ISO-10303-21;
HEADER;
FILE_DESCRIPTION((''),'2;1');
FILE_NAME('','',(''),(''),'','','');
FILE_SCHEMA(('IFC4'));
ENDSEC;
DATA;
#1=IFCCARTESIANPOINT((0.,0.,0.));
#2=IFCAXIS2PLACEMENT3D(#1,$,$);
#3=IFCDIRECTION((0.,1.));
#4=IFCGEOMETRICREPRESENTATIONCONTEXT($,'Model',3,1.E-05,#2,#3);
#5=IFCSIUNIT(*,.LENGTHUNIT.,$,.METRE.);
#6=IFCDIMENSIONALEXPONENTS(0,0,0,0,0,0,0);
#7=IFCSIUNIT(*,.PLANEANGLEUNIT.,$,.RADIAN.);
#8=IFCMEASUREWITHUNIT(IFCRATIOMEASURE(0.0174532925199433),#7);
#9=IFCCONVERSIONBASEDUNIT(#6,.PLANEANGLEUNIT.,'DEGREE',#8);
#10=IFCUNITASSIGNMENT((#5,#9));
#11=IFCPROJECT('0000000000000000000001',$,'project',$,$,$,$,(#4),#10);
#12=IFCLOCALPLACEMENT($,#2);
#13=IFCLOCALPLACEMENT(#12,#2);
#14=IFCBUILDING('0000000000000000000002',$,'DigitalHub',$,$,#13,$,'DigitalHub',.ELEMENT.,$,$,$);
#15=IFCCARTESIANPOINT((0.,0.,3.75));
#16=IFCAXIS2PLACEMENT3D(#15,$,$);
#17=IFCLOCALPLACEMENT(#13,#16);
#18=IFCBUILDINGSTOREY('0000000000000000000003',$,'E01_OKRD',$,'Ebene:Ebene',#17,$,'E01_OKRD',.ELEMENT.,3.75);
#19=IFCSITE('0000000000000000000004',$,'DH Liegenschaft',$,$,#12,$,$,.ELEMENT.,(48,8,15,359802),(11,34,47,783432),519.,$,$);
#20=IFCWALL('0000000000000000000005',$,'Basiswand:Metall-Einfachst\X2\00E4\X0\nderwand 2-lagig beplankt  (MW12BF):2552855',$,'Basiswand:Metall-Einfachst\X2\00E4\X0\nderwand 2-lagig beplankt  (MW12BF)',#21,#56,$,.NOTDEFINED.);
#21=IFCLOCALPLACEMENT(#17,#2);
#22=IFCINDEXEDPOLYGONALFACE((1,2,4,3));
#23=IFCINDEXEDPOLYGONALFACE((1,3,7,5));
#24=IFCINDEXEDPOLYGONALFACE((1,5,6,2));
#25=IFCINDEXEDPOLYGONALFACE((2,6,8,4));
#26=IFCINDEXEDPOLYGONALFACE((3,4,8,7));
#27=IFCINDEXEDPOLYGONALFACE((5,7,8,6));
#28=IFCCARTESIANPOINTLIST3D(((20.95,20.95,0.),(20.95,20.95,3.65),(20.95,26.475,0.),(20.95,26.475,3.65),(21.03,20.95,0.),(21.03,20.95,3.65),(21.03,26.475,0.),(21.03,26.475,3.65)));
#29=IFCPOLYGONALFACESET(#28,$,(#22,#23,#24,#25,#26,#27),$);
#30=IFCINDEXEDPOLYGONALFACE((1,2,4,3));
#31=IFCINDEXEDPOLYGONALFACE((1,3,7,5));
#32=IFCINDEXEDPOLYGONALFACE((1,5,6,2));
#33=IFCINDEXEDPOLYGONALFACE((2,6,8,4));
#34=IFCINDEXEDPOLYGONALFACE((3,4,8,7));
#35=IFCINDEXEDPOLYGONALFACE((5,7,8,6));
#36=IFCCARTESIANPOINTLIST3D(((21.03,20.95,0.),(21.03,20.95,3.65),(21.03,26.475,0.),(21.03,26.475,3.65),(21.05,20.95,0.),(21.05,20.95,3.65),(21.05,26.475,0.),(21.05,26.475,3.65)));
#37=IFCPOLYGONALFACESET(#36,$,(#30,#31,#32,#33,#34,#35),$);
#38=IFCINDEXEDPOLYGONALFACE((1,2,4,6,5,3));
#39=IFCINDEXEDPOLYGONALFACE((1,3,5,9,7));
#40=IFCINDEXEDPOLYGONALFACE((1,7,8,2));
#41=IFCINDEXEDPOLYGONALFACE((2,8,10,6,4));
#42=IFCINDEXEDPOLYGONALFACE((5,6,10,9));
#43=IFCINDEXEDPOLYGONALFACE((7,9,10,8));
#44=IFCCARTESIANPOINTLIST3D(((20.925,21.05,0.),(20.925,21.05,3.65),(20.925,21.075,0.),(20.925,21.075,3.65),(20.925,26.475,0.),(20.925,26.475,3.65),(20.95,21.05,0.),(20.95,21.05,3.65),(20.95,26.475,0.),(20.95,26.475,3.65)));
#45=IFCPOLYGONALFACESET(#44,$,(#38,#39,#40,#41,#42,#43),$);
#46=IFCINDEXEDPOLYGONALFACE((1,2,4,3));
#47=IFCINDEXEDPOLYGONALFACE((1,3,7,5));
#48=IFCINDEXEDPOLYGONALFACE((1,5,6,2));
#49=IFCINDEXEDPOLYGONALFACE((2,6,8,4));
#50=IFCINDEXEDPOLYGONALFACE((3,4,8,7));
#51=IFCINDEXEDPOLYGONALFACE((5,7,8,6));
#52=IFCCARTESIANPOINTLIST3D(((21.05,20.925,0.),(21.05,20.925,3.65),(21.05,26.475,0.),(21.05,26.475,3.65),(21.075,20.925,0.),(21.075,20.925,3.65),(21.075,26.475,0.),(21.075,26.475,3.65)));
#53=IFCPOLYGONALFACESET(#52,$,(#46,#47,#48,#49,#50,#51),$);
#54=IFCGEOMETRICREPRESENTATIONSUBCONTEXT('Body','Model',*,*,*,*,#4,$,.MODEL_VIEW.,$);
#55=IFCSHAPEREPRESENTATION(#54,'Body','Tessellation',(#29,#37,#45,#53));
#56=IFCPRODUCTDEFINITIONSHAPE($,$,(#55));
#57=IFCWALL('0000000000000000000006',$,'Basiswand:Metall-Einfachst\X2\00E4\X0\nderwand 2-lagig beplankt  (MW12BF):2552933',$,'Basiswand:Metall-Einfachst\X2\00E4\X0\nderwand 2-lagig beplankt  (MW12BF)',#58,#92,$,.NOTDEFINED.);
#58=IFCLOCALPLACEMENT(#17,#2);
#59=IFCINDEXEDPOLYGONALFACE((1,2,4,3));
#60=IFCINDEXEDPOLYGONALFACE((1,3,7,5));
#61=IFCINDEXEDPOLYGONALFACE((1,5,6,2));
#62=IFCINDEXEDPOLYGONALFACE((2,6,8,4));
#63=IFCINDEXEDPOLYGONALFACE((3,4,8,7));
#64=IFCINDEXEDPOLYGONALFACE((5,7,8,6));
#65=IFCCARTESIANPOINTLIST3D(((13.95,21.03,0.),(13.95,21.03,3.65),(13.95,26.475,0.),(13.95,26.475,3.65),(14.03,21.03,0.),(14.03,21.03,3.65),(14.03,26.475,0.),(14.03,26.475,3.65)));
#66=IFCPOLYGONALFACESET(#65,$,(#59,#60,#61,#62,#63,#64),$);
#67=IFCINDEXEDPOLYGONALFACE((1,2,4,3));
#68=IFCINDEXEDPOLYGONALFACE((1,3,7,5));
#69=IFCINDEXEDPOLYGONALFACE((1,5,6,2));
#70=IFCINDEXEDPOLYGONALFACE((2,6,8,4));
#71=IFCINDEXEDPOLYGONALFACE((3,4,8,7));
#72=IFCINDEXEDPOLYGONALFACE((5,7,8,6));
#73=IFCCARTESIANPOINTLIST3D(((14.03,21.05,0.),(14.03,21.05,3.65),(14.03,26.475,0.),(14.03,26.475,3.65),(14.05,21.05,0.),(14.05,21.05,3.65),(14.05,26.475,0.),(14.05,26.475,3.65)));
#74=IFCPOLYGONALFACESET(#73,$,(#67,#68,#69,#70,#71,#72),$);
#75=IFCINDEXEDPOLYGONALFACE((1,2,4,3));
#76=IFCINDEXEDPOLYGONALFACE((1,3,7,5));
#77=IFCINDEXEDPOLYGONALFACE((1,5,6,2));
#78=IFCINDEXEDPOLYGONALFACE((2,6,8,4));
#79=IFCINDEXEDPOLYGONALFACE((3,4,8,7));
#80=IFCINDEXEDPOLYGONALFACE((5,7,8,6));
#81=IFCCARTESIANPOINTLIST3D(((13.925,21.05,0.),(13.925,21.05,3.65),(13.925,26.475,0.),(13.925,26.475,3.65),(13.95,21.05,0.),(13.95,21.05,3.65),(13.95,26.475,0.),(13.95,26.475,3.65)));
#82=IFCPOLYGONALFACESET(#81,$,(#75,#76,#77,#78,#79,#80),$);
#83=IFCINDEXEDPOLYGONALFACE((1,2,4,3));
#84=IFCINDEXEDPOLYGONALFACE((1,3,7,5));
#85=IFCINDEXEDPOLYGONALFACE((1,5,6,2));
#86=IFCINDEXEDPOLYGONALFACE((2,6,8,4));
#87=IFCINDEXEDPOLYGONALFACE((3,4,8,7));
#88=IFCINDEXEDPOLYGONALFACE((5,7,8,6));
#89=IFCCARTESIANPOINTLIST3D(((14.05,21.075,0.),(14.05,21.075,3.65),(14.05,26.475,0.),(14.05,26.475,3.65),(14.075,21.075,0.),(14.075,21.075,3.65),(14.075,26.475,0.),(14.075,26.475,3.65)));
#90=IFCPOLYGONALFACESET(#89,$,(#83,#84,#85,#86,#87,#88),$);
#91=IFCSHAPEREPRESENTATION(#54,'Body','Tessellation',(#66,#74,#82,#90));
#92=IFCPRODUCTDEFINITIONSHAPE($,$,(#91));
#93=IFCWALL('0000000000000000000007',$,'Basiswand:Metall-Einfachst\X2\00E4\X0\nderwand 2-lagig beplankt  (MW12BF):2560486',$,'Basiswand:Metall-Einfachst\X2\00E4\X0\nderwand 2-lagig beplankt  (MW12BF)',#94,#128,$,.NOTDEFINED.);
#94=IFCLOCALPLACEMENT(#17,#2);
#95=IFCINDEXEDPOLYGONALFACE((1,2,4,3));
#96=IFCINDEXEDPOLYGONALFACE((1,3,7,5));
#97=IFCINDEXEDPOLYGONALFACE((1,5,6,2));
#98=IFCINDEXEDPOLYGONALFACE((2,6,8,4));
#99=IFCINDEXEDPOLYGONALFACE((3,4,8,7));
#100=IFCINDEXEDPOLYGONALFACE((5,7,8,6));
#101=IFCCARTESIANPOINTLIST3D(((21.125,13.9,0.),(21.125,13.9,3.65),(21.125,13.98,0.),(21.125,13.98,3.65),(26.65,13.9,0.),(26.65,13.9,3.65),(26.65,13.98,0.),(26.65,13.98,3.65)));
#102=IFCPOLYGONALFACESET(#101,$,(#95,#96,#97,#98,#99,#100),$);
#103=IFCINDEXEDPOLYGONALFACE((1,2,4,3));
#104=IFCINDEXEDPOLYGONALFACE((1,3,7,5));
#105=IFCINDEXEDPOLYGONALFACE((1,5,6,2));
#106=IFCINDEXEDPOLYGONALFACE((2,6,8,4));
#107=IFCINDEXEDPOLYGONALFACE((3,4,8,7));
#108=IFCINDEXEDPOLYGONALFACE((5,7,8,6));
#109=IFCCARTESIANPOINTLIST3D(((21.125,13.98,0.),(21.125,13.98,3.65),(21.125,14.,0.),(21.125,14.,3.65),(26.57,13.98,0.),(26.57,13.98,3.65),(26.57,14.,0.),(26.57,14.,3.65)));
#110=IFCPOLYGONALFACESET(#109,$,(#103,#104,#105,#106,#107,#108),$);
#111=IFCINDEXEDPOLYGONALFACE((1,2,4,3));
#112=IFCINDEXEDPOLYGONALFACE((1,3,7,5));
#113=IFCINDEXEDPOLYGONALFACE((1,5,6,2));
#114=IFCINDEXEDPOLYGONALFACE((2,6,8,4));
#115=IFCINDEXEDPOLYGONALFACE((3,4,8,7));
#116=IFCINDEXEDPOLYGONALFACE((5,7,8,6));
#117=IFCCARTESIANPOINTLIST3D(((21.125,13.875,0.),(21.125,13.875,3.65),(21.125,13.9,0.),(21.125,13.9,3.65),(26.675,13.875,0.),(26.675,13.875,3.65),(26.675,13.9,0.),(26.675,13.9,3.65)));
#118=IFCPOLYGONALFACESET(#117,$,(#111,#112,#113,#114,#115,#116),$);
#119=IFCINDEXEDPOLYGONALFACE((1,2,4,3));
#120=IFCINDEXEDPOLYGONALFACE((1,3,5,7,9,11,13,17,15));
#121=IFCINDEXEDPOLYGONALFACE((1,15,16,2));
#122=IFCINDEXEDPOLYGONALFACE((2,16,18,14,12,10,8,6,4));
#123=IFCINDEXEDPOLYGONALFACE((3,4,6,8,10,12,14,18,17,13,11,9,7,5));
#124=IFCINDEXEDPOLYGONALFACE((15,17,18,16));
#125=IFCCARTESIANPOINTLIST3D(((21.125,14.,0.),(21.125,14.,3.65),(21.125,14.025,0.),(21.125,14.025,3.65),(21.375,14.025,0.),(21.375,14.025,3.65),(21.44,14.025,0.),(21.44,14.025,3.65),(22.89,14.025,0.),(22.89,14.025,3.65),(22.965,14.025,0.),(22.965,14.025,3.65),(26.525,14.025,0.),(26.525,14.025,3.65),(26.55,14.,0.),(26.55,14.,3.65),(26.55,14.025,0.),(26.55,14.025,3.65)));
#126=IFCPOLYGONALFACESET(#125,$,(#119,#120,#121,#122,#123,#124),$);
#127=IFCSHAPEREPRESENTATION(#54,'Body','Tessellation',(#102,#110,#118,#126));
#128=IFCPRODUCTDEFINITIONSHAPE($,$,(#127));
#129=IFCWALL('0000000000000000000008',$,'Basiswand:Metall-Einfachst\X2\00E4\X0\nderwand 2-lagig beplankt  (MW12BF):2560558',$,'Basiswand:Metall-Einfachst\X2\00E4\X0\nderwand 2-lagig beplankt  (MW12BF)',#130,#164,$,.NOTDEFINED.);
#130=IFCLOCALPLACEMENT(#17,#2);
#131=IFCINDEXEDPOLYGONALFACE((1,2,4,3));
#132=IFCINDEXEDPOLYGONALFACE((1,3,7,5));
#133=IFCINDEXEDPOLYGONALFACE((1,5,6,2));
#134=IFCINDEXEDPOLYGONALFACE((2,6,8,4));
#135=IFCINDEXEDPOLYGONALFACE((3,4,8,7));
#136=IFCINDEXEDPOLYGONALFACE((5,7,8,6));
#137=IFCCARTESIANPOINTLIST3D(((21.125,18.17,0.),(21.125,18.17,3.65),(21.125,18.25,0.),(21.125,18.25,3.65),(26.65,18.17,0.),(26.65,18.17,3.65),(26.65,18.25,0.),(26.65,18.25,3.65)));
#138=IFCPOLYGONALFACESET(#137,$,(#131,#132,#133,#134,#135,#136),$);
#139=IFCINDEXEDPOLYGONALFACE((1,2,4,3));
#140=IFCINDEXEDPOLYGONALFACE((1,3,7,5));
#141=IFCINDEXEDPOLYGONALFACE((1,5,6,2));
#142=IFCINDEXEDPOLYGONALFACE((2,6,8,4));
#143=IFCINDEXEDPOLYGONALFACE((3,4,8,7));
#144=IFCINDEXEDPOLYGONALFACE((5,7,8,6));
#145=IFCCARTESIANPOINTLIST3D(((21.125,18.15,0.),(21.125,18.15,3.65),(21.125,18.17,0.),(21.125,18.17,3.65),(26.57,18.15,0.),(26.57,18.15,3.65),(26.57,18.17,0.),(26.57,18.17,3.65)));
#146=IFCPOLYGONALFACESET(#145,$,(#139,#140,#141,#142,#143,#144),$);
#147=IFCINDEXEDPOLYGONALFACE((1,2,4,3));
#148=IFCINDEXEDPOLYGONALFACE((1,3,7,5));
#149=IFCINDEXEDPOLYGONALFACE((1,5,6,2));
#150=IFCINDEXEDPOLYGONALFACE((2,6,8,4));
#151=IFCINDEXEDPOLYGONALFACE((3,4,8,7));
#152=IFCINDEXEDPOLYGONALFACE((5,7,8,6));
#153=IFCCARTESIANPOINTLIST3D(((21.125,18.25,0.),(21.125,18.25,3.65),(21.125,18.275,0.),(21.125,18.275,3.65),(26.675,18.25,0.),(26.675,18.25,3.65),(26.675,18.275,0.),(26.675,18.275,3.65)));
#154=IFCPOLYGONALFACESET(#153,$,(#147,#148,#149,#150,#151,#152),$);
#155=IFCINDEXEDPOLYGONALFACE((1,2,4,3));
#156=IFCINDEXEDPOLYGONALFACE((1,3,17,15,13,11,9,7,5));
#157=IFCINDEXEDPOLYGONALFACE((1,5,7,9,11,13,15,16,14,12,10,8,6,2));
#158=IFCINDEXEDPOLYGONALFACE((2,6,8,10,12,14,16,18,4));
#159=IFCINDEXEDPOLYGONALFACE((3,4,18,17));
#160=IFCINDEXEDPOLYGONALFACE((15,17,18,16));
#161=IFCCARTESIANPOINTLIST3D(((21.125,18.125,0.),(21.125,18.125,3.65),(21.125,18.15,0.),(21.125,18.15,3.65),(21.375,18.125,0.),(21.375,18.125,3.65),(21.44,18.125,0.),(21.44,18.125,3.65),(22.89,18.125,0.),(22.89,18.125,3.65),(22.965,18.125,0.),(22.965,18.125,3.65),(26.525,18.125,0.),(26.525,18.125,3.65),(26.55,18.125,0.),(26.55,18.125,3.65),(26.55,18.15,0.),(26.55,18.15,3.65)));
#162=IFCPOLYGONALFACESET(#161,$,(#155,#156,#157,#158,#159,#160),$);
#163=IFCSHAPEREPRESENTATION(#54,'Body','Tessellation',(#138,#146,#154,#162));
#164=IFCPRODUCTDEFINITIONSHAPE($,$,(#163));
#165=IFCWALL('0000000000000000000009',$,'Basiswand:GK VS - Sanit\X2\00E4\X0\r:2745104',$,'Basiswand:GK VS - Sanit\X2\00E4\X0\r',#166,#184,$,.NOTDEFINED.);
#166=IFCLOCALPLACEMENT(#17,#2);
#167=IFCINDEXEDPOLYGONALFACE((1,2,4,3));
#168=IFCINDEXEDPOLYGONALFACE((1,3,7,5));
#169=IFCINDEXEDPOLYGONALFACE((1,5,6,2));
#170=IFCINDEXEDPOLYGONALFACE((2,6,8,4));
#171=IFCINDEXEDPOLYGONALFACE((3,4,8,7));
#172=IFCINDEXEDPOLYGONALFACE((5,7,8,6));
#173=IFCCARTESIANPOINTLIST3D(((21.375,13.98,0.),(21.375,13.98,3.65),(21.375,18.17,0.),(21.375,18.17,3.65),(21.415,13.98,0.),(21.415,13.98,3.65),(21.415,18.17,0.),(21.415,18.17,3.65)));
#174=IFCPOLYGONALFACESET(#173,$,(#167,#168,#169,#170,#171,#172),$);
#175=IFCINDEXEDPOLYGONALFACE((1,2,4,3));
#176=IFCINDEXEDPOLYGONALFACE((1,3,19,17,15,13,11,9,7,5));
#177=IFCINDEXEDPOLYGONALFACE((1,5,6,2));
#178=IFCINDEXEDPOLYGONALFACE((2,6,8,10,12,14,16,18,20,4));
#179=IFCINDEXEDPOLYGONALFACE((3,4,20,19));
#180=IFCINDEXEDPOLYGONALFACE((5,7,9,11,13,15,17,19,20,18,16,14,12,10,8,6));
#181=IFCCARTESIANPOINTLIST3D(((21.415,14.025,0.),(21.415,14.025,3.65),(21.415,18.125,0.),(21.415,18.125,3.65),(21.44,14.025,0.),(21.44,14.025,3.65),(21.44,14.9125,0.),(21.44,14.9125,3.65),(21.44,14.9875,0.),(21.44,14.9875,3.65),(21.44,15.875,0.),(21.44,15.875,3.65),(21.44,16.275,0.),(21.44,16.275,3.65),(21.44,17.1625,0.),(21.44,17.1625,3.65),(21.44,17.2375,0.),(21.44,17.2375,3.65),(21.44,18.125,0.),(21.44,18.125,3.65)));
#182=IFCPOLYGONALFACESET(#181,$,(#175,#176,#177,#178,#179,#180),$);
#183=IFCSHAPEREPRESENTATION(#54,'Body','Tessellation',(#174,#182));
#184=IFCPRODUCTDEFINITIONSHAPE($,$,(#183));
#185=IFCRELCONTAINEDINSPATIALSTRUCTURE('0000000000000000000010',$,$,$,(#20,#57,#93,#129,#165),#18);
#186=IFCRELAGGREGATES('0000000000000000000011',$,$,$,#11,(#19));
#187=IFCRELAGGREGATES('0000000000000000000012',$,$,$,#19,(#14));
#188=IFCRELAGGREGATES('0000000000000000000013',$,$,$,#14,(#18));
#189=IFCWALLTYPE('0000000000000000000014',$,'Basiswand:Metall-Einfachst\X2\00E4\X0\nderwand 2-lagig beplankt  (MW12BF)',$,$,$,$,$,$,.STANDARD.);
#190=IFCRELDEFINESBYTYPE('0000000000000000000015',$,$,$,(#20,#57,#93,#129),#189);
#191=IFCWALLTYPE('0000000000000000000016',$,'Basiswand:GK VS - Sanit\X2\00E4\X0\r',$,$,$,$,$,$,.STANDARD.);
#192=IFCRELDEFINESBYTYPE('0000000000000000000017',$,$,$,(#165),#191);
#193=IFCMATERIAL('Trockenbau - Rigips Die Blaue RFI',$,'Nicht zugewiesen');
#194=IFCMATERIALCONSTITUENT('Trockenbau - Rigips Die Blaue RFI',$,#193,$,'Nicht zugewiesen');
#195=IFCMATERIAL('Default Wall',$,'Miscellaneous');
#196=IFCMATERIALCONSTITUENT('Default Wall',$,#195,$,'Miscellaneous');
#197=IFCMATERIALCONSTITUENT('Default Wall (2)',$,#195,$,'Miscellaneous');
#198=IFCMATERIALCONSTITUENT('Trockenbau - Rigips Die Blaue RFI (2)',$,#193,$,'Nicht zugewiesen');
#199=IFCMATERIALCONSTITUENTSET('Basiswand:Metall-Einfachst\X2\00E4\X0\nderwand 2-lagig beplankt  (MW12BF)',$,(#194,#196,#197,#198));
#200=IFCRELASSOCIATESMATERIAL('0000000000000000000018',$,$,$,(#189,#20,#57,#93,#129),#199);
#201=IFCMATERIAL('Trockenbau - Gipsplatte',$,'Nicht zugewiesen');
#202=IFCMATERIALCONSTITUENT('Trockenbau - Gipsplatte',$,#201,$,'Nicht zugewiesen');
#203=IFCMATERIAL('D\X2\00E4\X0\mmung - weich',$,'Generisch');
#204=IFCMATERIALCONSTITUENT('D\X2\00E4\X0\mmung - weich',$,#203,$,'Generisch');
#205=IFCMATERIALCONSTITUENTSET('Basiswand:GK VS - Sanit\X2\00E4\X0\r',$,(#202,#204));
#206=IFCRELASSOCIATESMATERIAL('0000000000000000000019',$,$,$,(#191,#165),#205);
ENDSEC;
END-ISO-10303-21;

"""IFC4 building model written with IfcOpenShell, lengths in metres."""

from ifc_helpers import new_model, entity, si_unit, converted_unit, direction, frame, origin, place, context, subcontext, project, spatial, indexed_curve, outline, extrude, material, constituent, constituent_set, type_object, element, save


model = new_model("IFC4")

# Units and contexts
model_context = context("Model", 3, precision=1e-05, world=origin(), true_north=direction((0.0, 1.0)))
body_context = subcontext(model_context, "Body", "Model", "MODEL_VIEW")
ifc_project = project(units=[si_unit("LENGTHUNIT", "METRE"), converted_unit("PLANEANGLEUNIT", "DEGREE", entity("IfcRatioMeasure", 0.0174532925199433), si_unit("PLANEANGLEUNIT", "RADIAN"), dimensions=[0, 0, 0, 0, 0, 0, 0])], contexts=[model_context])

# Site, building, storey
site_placement = place(None, frame((0.0, 0.0, 0.0)))
site = spatial("IfcSite", under=ifc_project, at=site_placement, Name="DH Liegenschaft", CompositionType="ELEMENT", RefLatitude=(48, 8, 15, 359802), RefLongitude=(11, 34, 47, 783432), RefElevation=519.0)
building_placement = place(site_placement, origin())
building = spatial("IfcBuilding", under=site, at=building_placement, Name="DigitalHub", LongName="DigitalHub", CompositionType="ELEMENT")
storey_placement = place(building_placement, frame((0.0, 0.0, 3.75)))
storey = spatial("IfcBuildingStorey", under=building, at=storey_placement, Name="E01_OKRD", ObjectType="Ebene:Ebene", LongName="E01_OKRD", CompositionType="ELEMENT", Elevation=3.75)

# Walls
ifc_material_1 = material(Name="Trockenbau - Rigips Die Blaue RFI", Category="Nicht zugewiesen")
ifc_constituent_1 = constituent(ifc_material_1, Name="Trockenbau - Rigips Die Blaue RFI", Category="Nicht zugewiesen")
ifc_material_2 = material(Name="Default Wall", Category="Miscellaneous")
ifc_constituent_2 = constituent(ifc_material_2, Name="Default Wall", Category="Miscellaneous")
ifc_constituent_3 = constituent(ifc_material_2, Name="Default Wall (2)", Category="Miscellaneous")
ifc_constituent_4 = constituent(ifc_material_1, Name="Trockenbau - Rigips Die Blaue RFI (2)", Category="Nicht zugewiesen")
ifc_constituent_set_1 = constituent_set(constituents=[ifc_constituent_1, ifc_constituent_2, ifc_constituent_3, ifc_constituent_4], Name="Basiswand:Metall-Einfachständerwand 2-lagig beplankt  (MW12BF)")
wall_type_1 = type_object("IfcWallType", Name="Basiswand:Metall-Einfachständerwand 2-lagig beplankt  (MW12BF)", PredefinedType="STANDARD", material=ifc_constituent_set_1)
wall_1_placement = place(storey_placement, frame((21.0, 20.925, 0.0), z_axis=(0.0, 0.0, 1.0), x_axis=(0.0, 1.0, 0.0)))
element("IfcWall", 1, at=wall_1_placement, inside=storey, type_object=wall_type_1, material=ifc_constituent_set_1, Name="Basiswand:Metall-Einfachständerwand 2-lagig beplankt  (MW12BF):2552855", ObjectType="Basiswand:Metall-Einfachständerwand 2-lagig beplankt  (MW12BF)", PredefinedType="NOTDEFINED", context=body_context, shape_type="SweptSolid", body=[
    extrude(outline(indexed_curve([(-2.7625, -0.04), (2.7625, -0.04), (2.7625, 0.04), (-2.7625, 0.04), (-2.7625, -0.04)], self_intersect=False)), frame((2.7875, 0.01, 0.0)), (0.0, 0.0, 1.0), 3.65),
    extrude(outline(indexed_curve([(-2.7625, -0.01), (2.7625, -0.01), (2.7625, 0.01), (-2.7625, 0.01), (-2.7625, -0.01)], self_intersect=False)), frame((2.7875, -0.04, 0.0)), (0.0, 0.0, 1.0), 3.65),
    extrude(outline(indexed_curve([(2.15, -0.01), (2.175, -0.01), (2.175, 0.015), (-3.25, 0.015), (-3.25, -0.01), (2.15, -0.01)], self_intersect=False)), frame((2.3, 0.065, 0.0), z_axis=(0.0, 0.0, 1.0), x_axis=(-1.0, 0.0, 0.0)), (0.0, 0.0, 1.0), 3.65),
    extrude(outline(indexed_curve([(-0.0125, -2.775), (0.0125, -2.775), (0.0125, 2.775), (-0.0125, 2.775), (-0.0125, -2.775)], self_intersect=False)), frame((2.775, -0.0625, 0.0), z_axis=(0.0, 0.0, 1.0), x_axis=(0.0, 1.0, 0.0)), (0.0, 0.0, 1.0), 3.65),
])
wall_2_placement = place(storey_placement, frame((14.0, 21.075, 0.0), z_axis=(0.0, 0.0, 1.0), x_axis=(0.0, 1.0, 0.0)))
element("IfcWall", 2, at=wall_2_placement, inside=storey, type_object=wall_type_1, material=ifc_constituent_set_1, Name="Basiswand:Metall-Einfachständerwand 2-lagig beplankt  (MW12BF):2552933", ObjectType="Basiswand:Metall-Einfachständerwand 2-lagig beplankt  (MW12BF)", PredefinedType="NOTDEFINED", context=body_context, shape_type="SweptSolid", body=[
    extrude(outline(indexed_curve([(-2.7225, -0.04), (2.7225, -0.04), (2.7225, 0.04), (-2.7225, 0.04), (-2.7225, -0.04)], self_intersect=False)), frame((2.6775, 0.01, 0.0)), (0.0, 0.0, 1.0), 3.65),
    extrude(outline(indexed_curve([(-2.7125, -0.01), (2.7125, -0.01), (2.7125, 0.01), (-2.7125, 0.01), (-2.7125, -0.01)], self_intersect=False)), frame((2.6875, -0.04, 0.0)), (0.0, 0.0, 1.0), 3.65),
    extrude(outline(indexed_curve([(-0.0125, -2.7125), (0.0125, -2.7125), (0.0125, 2.7125), (-0.0125, 2.7125), (-0.0125, -2.7125)], self_intersect=False)), frame((2.6875, 0.0625, 0.0), z_axis=(0.0, 0.0, 1.0), x_axis=(0.0, -1.0, 0.0)), (0.0, 0.0, 1.0), 3.65),
    extrude(outline(indexed_curve([(-0.0125, -2.7), (0.0125, -2.7), (0.0125, 2.7), (-0.0125, 2.7), (-0.0125, -2.7)], self_intersect=False)), frame((2.7, -0.0625, 0.0), z_axis=(0.0, 0.0, 1.0), x_axis=(0.0, 1.0, 0.0)), (0.0, 0.0, 1.0), 3.65),
])

# Walls
wall_3_placement = place(storey_placement, frame((21.125, 13.95, 0.0)))
element("IfcWall", 3, at=wall_3_placement, inside=storey, type_object=wall_type_1, material=ifc_constituent_set_1, Name="Basiswand:Metall-Einfachständerwand 2-lagig beplankt  (MW12BF):2560486", ObjectType="Basiswand:Metall-Einfachständerwand 2-lagig beplankt  (MW12BF)", PredefinedType="NOTDEFINED", context=body_context, shape_type="SweptSolid", body=[
    extrude(outline(indexed_curve([(-2.7625, -0.04), (2.7625, -0.04), (2.7625, 0.04), (-2.7625, 0.04), (-2.7625, -0.04)], self_intersect=False)), frame((2.7625, -0.01, 0.0)), (0.0, 0.0, 1.0), 3.65),
    extrude(outline(indexed_curve([(-2.7225, -0.01), (2.7225, -0.01), (2.7225, 0.01), (-2.7225, 0.01), (-2.7225, -0.01)], self_intersect=False)), frame((2.7225, 0.04, 0.0)), (0.0, 0.0, 1.0), 3.65),
    extrude(outline(indexed_curve([(-0.0125, -2.775), (0.0125, -2.775), (0.0125, 2.775), (-0.0125, 2.775), (-0.0125, -2.775)], self_intersect=False)), frame((2.775, -0.0625, 0.0), z_axis=(0.0, 0.0, 1.0), x_axis=(0.0, 1.0, 0.0)), (0.0, 0.0, 1.0), 3.65),
    extrude(outline(indexed_curve([(-3.1311, -0.0056), (0.4289, -0.0056), (0.5039, -0.0056), (1.9539, -0.0056), (2.0189, -0.0056), (2.2689, -0.0056), (2.2689, 0.0194), (-3.1561, 0.0194), (-3.1561, -0.0056), (-3.1311, -0.0056)], self_intersect=False)), frame((2.2689, 0.0694, 0.0), z_axis=(0.0, 0.0, 1.0), x_axis=(-1.0, 0.0, 0.0)), (0.0, 0.0, 1.0), 3.65),
])
wall_4_placement = place(storey_placement, frame((21.125, 18.2, 0.0)))
element("IfcWall", 4, at=wall_4_placement, inside=storey, type_object=wall_type_1, material=ifc_constituent_set_1, Name="Basiswand:Metall-Einfachständerwand 2-lagig beplankt  (MW12BF):2560558", ObjectType="Basiswand:Metall-Einfachständerwand 2-lagig beplankt  (MW12BF)", PredefinedType="NOTDEFINED", context=body_context, shape_type="SweptSolid", body=[
    extrude(outline(indexed_curve([(-2.7625, -0.04), (2.7625, -0.04), (2.7625, 0.04), (-2.7625, 0.04), (-2.7625, -0.04)], self_intersect=False)), frame((2.7625, 0.01, 0.0)), (0.0, 0.0, 1.0), 3.65),
    extrude(outline(indexed_curve([(-2.7225, -0.01), (2.7225, -0.01), (2.7225, 0.01), (-2.7225, 0.01), (-2.7225, -0.01)], self_intersect=False)), frame((2.7225, -0.04, 0.0)), (0.0, 0.0, 1.0), 3.65),
    extrude(outline(indexed_curve([(-0.0125, -2.775), (0.0125, -2.775), (0.0125, 2.775), (-0.0125, 2.775), (-0.0125, -2.775)], self_intersect=False)), frame((2.775, 0.0625, 0.0), z_axis=(0.0, 0.0, 1.0), x_axis=(0.0, -1.0, 0.0)), (0.0, 0.0, 1.0), 3.65),
    extrude(outline(indexed_curve([(-2.0189, -0.0056), (-1.9539, -0.0056), (-0.5039, -0.0056), (-0.4289, -0.0056), (3.1311, -0.0056), (3.1561, -0.0056), (3.1561, 0.0194), (-2.2689, 0.0194), (-2.2689, -0.0056), (-2.0189, -0.0056)], self_intersect=False)), frame((2.2689, -0.0694, 0.0)), (0.0, 0.0, 1.0), 3.65),
])
ifc_material_3 = material(Name="Trockenbau - Gipsplatte", Category="Nicht zugewiesen")
ifc_constituent_5 = constituent(ifc_material_3, Name="Trockenbau - Gipsplatte", Category="Nicht zugewiesen")
ifc_material_4 = material(Name="Dämmung - weich", Category="Generisch")
ifc_constituent_6 = constituent(ifc_material_4, Name="Dämmung - weich", Category="Generisch")
ifc_constituent_set_2 = constituent_set(constituents=[ifc_constituent_5, ifc_constituent_6], Name="Basiswand:GK VS - Sanitär")
wall_type_2 = type_object("IfcWallType", Name="Basiswand:GK VS - Sanitär", PredefinedType="STANDARD", material=ifc_constituent_set_2)
wall_5_placement = place(storey_placement, frame((21.4075, 18.125, 0.0), z_axis=(0.0, 0.0, 1.0), x_axis=(0.0, -1.0, 0.0)))
element("IfcWall", 5, at=wall_5_placement, inside=storey, type_object=wall_type_2, material=ifc_constituent_set_2, Name="Basiswand:GK VS - Sanitär:2745104", ObjectType="Basiswand:GK VS - Sanitär", PredefinedType="NOTDEFINED", context=body_context, shape_type="SweptSolid", body=[
    extrude(outline(indexed_curve([(-0.02, -2.095), (0.02, -2.095), (0.02, 2.095), (-0.02, 2.095), (-0.02, -2.095)], self_intersect=False)), frame((2.05, -0.0125, 0.0), z_axis=(0.0, 0.0, 1.0), x_axis=(0.0, 1.0, 0.0)), (0.0, 0.0, 1.0), 3.65),
    extrude(outline(indexed_curve([(-1.1625, -0.005), (-1.0875, -0.005), (-0.2, -0.005), (0.2, -0.005), (1.0875, -0.005), (1.1625, -0.005), (2.05, -0.005), (2.05, 0.02), (-2.05, 0.02), (-2.05, -0.005), (-1.1625, -0.005)], self_intersect=False)), frame((2.05, 0.0275, 0.0), z_axis=(0.0, 0.0, 1.0), x_axis=(-1.0, 0.0, 0.0)), (0.0, 0.0, 1.0), 3.65),
])

save(model, "model.ifc")
